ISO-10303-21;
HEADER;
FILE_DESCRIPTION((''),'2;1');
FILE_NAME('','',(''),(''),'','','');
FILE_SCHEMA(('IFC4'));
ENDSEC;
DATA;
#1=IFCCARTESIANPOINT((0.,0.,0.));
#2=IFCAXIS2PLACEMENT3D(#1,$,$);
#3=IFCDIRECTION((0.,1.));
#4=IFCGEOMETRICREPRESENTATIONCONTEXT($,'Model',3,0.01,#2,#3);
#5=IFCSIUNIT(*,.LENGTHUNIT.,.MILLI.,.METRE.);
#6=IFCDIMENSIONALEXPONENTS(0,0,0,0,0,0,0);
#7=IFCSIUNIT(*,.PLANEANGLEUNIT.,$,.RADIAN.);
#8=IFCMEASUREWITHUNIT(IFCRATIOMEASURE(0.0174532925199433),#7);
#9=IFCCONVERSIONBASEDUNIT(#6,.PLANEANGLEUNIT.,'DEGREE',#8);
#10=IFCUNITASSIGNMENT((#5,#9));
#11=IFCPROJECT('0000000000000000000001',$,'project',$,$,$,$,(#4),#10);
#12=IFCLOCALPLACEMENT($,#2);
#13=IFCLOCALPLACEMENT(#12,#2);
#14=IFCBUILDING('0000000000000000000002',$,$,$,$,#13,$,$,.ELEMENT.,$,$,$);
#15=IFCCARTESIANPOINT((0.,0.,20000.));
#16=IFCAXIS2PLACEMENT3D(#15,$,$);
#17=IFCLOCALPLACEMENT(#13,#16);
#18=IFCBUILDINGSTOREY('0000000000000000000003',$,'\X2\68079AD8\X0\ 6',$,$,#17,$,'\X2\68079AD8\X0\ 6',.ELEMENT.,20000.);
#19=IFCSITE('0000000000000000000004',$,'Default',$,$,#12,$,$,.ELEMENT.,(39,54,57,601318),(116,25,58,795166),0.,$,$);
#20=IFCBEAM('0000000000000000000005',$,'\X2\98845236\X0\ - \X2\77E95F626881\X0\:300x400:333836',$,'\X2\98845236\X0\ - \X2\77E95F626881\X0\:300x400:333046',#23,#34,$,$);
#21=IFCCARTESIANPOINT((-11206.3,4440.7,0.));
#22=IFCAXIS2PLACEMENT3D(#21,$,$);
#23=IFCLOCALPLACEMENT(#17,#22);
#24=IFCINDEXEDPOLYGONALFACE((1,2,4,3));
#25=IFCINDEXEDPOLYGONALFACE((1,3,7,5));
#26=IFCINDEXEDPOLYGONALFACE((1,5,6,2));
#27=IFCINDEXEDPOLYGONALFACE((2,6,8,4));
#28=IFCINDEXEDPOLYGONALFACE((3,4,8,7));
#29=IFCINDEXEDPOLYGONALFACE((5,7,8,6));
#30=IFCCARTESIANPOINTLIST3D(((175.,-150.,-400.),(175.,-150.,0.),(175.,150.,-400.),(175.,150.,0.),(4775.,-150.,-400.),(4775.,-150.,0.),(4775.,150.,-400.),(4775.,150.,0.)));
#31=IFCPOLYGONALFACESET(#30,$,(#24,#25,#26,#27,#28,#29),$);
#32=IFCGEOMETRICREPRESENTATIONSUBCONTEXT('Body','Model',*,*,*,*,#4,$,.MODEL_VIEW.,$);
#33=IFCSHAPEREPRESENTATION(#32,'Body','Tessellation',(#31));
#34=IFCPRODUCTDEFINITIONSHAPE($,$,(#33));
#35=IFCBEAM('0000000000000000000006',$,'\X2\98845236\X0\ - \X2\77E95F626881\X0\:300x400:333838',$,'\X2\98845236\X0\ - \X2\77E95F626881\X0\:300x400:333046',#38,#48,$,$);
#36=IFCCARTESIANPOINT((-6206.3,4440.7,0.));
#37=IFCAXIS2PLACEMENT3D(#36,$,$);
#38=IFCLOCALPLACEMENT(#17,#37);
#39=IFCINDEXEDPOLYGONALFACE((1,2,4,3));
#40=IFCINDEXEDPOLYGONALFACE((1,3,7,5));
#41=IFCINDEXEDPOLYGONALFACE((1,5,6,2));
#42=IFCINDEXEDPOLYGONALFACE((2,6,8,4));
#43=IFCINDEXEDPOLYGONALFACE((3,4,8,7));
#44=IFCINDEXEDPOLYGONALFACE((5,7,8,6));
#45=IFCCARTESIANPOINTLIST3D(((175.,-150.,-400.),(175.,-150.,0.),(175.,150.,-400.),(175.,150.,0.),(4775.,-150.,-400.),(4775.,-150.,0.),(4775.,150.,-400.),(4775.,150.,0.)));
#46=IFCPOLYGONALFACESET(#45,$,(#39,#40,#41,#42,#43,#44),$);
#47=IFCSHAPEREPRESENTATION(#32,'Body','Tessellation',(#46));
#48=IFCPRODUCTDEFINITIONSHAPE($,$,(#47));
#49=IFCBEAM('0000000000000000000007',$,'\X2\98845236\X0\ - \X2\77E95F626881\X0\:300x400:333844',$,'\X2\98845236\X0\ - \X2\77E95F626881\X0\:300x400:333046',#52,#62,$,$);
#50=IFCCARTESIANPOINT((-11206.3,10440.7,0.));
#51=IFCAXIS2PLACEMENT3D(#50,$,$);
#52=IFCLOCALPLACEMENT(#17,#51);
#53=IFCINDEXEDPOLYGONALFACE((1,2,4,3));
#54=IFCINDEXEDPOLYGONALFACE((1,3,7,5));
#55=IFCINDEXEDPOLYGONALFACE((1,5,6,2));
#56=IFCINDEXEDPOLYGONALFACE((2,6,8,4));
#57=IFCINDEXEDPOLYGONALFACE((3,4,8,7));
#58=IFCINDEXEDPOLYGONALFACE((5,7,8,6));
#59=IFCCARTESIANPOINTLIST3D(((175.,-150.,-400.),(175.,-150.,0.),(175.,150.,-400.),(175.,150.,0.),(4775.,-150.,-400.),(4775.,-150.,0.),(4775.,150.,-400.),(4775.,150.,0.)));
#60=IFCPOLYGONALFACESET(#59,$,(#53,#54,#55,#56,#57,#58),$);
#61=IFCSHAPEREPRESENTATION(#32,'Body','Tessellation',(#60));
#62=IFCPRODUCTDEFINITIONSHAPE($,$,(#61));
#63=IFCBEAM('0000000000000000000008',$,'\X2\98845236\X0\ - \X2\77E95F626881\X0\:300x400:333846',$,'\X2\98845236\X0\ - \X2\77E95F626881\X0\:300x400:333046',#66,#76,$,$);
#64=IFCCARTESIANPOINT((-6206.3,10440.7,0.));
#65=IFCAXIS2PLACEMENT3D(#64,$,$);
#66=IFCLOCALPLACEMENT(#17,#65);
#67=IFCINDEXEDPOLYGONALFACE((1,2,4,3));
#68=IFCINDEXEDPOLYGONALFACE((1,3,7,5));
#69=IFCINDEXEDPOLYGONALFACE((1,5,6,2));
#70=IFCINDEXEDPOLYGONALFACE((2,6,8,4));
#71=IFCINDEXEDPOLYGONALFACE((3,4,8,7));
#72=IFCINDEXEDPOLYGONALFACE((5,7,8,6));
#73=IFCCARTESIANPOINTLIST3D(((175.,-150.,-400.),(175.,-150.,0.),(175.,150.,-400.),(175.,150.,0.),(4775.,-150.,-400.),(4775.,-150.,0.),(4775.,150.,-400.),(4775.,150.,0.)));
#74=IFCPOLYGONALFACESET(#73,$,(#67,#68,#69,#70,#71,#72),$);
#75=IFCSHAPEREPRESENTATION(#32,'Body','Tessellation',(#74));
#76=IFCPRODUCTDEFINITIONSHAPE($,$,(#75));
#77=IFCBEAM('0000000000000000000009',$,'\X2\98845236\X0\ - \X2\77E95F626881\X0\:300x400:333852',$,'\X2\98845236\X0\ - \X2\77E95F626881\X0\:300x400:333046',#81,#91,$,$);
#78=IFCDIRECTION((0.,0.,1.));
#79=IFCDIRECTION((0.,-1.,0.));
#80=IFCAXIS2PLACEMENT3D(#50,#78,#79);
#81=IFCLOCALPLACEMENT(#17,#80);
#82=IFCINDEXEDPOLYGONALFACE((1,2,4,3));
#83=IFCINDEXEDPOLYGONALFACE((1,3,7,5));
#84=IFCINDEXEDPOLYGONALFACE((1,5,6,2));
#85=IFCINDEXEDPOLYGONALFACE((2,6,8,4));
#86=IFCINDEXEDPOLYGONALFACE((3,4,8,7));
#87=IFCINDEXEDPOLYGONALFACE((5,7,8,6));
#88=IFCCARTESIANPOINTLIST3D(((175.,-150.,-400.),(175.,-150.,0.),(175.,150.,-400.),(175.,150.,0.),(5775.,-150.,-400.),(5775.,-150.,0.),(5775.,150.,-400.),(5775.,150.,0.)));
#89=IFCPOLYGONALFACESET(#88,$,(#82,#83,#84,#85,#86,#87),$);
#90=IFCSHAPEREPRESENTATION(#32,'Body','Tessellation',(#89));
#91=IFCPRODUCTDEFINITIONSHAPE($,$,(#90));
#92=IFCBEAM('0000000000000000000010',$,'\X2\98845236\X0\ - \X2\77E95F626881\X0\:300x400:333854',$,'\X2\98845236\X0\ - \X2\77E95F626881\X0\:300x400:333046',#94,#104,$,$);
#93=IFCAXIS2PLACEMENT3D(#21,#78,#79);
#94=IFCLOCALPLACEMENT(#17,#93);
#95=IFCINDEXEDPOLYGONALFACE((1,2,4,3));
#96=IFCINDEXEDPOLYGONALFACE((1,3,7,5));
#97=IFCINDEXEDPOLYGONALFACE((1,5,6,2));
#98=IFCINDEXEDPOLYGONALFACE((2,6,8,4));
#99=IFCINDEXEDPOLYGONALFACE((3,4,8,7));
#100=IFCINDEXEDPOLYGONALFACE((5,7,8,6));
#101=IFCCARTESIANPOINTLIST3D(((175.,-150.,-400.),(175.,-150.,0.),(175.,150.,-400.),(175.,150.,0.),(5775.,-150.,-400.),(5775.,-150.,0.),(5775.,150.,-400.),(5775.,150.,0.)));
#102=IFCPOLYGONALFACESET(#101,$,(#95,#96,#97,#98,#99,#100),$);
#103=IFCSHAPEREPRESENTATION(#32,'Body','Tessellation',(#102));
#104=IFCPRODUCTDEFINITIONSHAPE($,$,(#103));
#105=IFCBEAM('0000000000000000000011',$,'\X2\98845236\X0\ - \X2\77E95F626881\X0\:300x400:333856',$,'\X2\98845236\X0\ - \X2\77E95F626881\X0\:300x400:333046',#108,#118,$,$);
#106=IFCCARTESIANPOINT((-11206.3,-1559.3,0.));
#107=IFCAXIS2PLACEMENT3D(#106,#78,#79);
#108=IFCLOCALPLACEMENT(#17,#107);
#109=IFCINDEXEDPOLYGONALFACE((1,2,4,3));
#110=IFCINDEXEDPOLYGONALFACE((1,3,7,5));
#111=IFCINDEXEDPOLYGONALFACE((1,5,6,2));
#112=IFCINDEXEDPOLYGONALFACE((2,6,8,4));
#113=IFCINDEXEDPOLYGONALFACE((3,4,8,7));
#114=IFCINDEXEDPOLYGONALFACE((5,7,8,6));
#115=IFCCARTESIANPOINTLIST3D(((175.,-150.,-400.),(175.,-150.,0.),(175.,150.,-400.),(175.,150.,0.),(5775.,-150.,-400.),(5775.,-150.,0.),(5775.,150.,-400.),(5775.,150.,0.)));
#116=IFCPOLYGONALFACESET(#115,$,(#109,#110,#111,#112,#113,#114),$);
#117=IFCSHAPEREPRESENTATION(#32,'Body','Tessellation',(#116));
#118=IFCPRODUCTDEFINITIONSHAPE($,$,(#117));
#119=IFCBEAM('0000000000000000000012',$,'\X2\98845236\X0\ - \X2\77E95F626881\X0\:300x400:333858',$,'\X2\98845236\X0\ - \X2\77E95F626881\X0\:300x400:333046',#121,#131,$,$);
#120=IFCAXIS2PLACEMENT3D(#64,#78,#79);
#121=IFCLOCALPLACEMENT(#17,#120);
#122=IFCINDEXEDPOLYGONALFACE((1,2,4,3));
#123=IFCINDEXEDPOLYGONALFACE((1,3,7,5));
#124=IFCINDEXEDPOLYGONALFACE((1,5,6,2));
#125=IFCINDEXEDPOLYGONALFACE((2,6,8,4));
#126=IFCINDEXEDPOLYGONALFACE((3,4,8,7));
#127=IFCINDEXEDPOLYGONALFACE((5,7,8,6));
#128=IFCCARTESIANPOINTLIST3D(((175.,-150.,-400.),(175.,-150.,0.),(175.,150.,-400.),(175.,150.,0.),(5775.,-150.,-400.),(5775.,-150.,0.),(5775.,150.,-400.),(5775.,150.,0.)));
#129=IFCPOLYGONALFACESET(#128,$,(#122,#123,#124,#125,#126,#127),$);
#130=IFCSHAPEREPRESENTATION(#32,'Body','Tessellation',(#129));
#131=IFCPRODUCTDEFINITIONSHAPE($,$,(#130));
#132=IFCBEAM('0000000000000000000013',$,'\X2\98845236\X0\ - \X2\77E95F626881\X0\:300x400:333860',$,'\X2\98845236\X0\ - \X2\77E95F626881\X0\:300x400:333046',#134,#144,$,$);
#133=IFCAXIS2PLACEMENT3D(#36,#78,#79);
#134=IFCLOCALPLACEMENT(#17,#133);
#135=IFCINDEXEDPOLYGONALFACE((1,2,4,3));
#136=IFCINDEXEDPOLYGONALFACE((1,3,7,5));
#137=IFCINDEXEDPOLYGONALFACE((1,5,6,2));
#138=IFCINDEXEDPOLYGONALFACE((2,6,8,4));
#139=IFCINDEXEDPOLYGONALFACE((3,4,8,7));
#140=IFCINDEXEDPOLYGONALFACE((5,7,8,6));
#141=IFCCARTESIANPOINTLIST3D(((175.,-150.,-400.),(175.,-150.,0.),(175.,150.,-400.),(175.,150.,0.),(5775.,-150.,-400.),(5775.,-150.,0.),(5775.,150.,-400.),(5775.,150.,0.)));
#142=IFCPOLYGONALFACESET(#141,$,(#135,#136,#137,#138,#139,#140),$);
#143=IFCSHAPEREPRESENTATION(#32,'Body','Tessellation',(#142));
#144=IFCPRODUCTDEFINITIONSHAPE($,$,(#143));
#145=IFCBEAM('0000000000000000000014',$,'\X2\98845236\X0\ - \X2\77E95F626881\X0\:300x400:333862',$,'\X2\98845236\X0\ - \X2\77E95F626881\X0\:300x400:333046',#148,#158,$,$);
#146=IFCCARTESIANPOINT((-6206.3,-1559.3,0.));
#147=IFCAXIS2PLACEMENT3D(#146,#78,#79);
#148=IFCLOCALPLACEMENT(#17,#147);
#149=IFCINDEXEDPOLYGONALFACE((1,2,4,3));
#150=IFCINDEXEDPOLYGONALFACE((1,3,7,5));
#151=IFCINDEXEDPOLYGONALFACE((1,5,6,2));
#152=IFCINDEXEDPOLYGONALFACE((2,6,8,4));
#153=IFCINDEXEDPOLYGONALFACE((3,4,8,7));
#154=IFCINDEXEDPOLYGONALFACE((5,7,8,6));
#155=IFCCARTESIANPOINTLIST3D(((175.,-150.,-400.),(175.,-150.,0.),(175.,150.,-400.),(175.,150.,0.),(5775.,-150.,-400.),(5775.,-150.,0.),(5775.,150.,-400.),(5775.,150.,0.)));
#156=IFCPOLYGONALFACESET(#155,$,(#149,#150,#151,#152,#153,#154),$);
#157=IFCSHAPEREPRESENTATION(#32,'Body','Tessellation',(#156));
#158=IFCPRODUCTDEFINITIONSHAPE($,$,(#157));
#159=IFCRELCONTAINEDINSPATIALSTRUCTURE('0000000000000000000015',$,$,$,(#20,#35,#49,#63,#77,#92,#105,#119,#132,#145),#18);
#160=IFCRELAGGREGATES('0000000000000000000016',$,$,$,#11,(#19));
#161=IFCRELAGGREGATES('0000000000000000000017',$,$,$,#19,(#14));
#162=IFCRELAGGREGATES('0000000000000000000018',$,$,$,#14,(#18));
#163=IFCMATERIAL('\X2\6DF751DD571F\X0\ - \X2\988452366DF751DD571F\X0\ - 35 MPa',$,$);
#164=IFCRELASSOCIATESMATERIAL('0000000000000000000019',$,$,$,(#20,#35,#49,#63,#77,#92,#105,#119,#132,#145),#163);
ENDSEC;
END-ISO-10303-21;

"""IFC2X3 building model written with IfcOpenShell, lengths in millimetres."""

from ifc_helpers import new_model, entity, si_unit, converted_unit, direction, frame, frame_2d, origin, origin_2d_with_axis, place, context, subcontext, project, spatial, rectangle, extrude, material, element, save


model = new_model("IFC2X3")

# Units and contexts
model_context = context("Model", 3, precision=0.01, world=origin(), true_north=direction((0.0, 1.0)))
body_context = subcontext(model_context, "Body", "Model", "MODEL_VIEW")
ifc_project = project(units=[si_unit("LENGTHUNIT", "METRE", prefix="MILLI"), converted_unit("PLANEANGLEUNIT", "DEGREE", entity("IfcRatioMeasure", 0.0174532925199433), si_unit("PLANEANGLEUNIT", "RADIAN"), dimensions=[0, 0, 0, 0, 0, 0, 0])], contexts=[model_context])

# Site, building, storey
site_placement = place(None, origin())
site = spatial("IfcSite", under=ifc_project, at=site_placement, Name="Default", CompositionType="ELEMENT", RefLatitude=(39, 54, 57, 601318), RefLongitude=(116, 25, 58, 795166), RefElevation=0.0)
building_placement = place(site_placement, origin())
building = spatial("IfcBuilding", under=site, at=building_placement, CompositionType="ELEMENT")
storey_placement = place(building_placement, frame((0.0, 0.0, 20000.0)))
storey = spatial("IfcBuildingStorey", under=building, at=storey_placement, Name="标高 6", LongName="标高 6", CompositionType="ELEMENT", Elevation=20000.0)

# Shared definitions
ifc_material = material(Name="混凝土 - 预制混凝土 - 35 MPa")

# Beams
beam_1_placement = place(storey_placement, frame((-11206.3, 4440.7, 0.0)))
element("IfcBeam", 1, at=beam_1_placement, inside=storey, material=ifc_material, Name="预制 - 矩形梁:300x400:333836", ObjectType="预制 - 矩形梁:300x400:333046", context=body_context, shape_type="SweptSolid", body=[
    extrude(rectangle(XDim=400.0, YDim=300.0, at=frame_2d((0.0, 0.0), x_axis=(1.0, 0.0))), frame((175.0, 0.0, -200.0), z_axis=(1.0, 0.0, 0.0), x_axis=(0.0, 0.0, -1.0)), (0.0, 0.0, 1.0), 4600.0),
])
beam_2_placement = place(storey_placement, frame((-6206.3, 4440.7, 0.0)))
element("IfcBeam", 2, at=beam_2_placement, inside=storey, material=ifc_material, Name="预制 - 矩形梁:300x400:333838", ObjectType="预制 - 矩形梁:300x400:333046", context=body_context, shape_type="SweptSolid", body=[
    extrude(rectangle(XDim=400.0, YDim=300.0, at=frame_2d((0.0, 0.0), x_axis=(1.0, 0.0))), frame((175.0, 0.0, -200.0), z_axis=(1.0, 0.0, 0.0), x_axis=(0.0, 0.0, -1.0)), (0.0, 0.0, 1.0), 4600.0),
])
beam_3_placement = place(storey_placement, frame((-11206.3, 10440.7, 0.0)))
element("IfcBeam", 3, at=beam_3_placement, inside=storey, material=ifc_material, Name="预制 - 矩形梁:300x400:333844", ObjectType="预制 - 矩形梁:300x400:333046", context=body_context, shape_type="SweptSolid", body=[
    extrude(rectangle(XDim=400.0, YDim=300.0, at=frame_2d((0.0, 0.0), x_axis=(1.0, 0.0))), frame((175.0, 0.0, -200.0), z_axis=(1.0, 0.0, 0.0), x_axis=(0.0, 0.0, -1.0)), (0.0, 0.0, 1.0), 4600.0),
])
beam_4_placement = place(storey_placement, frame((-6206.3, 10440.7, 0.0)))
element("IfcBeam", 4, at=beam_4_placement, inside=storey, material=ifc_material, Name="预制 - 矩形梁:300x400:333846", ObjectType="预制 - 矩形梁:300x400:333046", context=body_context, shape_type="SweptSolid", body=[
    extrude(rectangle(XDim=400.0, YDim=300.0, at=frame_2d((0.0, 0.0), x_axis=(1.0, 0.0))), frame((175.0, 0.0, -200.0), z_axis=(1.0, 0.0, 0.0), x_axis=(0.0, 0.0, -1.0)), (0.0, 0.0, 1.0), 4600.0),
])
for number, where, z_axis, x_axis, name in (
    (5, (-11206.3, 10440.7, 0.0), (0.0, 0.0, 1.0), (0.0, -1.0, 0.0), "预制 - 矩形梁:300x400:333852"),
    (6, (-11206.3, 4440.7, 0.0), (0.0, 0.0, 1.0), (0.0, -1.0, 0.0), "预制 - 矩形梁:300x400:333854"),
):
    element("IfcBeam", number, at=place(storey_placement, frame(where, z_axis=z_axis, x_axis=x_axis)), inside=storey, material=ifc_material, Name=name, ObjectType="预制 - 矩形梁:300x400:333046", context=body_context, shape_type="SweptSolid", body=[
        extrude(rectangle(XDim=400.0, YDim=300.0, at=origin_2d_with_axis()), frame((175.0, 0.0, -200.0), z_axis=(1.0, 0.0, 0.0), x_axis=(0.0, 0.0, -1.0)), (0.0, 0.0, 1.0), 5600.0),
    ])
beam_5_placement = place(storey_placement, frame((-11206.3, -1559.3, 0.0), z_axis=(0.0, 0.0, 1.0), x_axis=(0.0, -1.0, 0.0)))
element("IfcBeam", 7, at=beam_5_placement, inside=storey, material=ifc_material, Name="预制 - 矩形梁:300x400:333856", ObjectType="预制 - 矩形梁:300x400:333046", context=body_context, shape_type="SweptSolid", body=[
    extrude(rectangle(XDim=400.0, YDim=300.0, at=frame_2d((0.0, 0.0), x_axis=(1.0, 0.0))), frame((175.0, 0.0, -200.0), z_axis=(1.0, 0.0, 0.0), x_axis=(0.0, 0.0, -1.0)), (0.0, 0.0, 1.0), 5600.0),
])
for number, where, z_axis, x_axis, name in (
    (8, (-6206.3, 10440.7, 0.0), (0.0, 0.0, 1.0), (0.0, -1.0, 0.0), "预制 - 矩形梁:300x400:333858"),
    (9, (-6206.3, 4440.7, 0.0), (0.0, 0.0, 1.0), (0.0, -1.0, 0.0), "预制 - 矩形梁:300x400:333860"),
    (10, (-6206.3, -1559.3, 0.0), (0.0, 0.0, 1.0), (0.0, -1.0, 0.0), "预制 - 矩形梁:300x400:333862"),
):
    element("IfcBeam", number, at=place(storey_placement, frame(where, z_axis=z_axis, x_axis=x_axis)), inside=storey, material=ifc_material, Name=name, ObjectType="预制 - 矩形梁:300x400:333046", context=body_context, shape_type="SweptSolid", body=[
        extrude(rectangle(XDim=400.0, YDim=300.0, at=origin_2d_with_axis()), frame((175.0, 0.0, -200.0), z_axis=(1.0, 0.0, 0.0), x_axis=(0.0, 0.0, -1.0)), (0.0, 0.0, 1.0), 5600.0),
    ])

save(model, "model.ifc")
